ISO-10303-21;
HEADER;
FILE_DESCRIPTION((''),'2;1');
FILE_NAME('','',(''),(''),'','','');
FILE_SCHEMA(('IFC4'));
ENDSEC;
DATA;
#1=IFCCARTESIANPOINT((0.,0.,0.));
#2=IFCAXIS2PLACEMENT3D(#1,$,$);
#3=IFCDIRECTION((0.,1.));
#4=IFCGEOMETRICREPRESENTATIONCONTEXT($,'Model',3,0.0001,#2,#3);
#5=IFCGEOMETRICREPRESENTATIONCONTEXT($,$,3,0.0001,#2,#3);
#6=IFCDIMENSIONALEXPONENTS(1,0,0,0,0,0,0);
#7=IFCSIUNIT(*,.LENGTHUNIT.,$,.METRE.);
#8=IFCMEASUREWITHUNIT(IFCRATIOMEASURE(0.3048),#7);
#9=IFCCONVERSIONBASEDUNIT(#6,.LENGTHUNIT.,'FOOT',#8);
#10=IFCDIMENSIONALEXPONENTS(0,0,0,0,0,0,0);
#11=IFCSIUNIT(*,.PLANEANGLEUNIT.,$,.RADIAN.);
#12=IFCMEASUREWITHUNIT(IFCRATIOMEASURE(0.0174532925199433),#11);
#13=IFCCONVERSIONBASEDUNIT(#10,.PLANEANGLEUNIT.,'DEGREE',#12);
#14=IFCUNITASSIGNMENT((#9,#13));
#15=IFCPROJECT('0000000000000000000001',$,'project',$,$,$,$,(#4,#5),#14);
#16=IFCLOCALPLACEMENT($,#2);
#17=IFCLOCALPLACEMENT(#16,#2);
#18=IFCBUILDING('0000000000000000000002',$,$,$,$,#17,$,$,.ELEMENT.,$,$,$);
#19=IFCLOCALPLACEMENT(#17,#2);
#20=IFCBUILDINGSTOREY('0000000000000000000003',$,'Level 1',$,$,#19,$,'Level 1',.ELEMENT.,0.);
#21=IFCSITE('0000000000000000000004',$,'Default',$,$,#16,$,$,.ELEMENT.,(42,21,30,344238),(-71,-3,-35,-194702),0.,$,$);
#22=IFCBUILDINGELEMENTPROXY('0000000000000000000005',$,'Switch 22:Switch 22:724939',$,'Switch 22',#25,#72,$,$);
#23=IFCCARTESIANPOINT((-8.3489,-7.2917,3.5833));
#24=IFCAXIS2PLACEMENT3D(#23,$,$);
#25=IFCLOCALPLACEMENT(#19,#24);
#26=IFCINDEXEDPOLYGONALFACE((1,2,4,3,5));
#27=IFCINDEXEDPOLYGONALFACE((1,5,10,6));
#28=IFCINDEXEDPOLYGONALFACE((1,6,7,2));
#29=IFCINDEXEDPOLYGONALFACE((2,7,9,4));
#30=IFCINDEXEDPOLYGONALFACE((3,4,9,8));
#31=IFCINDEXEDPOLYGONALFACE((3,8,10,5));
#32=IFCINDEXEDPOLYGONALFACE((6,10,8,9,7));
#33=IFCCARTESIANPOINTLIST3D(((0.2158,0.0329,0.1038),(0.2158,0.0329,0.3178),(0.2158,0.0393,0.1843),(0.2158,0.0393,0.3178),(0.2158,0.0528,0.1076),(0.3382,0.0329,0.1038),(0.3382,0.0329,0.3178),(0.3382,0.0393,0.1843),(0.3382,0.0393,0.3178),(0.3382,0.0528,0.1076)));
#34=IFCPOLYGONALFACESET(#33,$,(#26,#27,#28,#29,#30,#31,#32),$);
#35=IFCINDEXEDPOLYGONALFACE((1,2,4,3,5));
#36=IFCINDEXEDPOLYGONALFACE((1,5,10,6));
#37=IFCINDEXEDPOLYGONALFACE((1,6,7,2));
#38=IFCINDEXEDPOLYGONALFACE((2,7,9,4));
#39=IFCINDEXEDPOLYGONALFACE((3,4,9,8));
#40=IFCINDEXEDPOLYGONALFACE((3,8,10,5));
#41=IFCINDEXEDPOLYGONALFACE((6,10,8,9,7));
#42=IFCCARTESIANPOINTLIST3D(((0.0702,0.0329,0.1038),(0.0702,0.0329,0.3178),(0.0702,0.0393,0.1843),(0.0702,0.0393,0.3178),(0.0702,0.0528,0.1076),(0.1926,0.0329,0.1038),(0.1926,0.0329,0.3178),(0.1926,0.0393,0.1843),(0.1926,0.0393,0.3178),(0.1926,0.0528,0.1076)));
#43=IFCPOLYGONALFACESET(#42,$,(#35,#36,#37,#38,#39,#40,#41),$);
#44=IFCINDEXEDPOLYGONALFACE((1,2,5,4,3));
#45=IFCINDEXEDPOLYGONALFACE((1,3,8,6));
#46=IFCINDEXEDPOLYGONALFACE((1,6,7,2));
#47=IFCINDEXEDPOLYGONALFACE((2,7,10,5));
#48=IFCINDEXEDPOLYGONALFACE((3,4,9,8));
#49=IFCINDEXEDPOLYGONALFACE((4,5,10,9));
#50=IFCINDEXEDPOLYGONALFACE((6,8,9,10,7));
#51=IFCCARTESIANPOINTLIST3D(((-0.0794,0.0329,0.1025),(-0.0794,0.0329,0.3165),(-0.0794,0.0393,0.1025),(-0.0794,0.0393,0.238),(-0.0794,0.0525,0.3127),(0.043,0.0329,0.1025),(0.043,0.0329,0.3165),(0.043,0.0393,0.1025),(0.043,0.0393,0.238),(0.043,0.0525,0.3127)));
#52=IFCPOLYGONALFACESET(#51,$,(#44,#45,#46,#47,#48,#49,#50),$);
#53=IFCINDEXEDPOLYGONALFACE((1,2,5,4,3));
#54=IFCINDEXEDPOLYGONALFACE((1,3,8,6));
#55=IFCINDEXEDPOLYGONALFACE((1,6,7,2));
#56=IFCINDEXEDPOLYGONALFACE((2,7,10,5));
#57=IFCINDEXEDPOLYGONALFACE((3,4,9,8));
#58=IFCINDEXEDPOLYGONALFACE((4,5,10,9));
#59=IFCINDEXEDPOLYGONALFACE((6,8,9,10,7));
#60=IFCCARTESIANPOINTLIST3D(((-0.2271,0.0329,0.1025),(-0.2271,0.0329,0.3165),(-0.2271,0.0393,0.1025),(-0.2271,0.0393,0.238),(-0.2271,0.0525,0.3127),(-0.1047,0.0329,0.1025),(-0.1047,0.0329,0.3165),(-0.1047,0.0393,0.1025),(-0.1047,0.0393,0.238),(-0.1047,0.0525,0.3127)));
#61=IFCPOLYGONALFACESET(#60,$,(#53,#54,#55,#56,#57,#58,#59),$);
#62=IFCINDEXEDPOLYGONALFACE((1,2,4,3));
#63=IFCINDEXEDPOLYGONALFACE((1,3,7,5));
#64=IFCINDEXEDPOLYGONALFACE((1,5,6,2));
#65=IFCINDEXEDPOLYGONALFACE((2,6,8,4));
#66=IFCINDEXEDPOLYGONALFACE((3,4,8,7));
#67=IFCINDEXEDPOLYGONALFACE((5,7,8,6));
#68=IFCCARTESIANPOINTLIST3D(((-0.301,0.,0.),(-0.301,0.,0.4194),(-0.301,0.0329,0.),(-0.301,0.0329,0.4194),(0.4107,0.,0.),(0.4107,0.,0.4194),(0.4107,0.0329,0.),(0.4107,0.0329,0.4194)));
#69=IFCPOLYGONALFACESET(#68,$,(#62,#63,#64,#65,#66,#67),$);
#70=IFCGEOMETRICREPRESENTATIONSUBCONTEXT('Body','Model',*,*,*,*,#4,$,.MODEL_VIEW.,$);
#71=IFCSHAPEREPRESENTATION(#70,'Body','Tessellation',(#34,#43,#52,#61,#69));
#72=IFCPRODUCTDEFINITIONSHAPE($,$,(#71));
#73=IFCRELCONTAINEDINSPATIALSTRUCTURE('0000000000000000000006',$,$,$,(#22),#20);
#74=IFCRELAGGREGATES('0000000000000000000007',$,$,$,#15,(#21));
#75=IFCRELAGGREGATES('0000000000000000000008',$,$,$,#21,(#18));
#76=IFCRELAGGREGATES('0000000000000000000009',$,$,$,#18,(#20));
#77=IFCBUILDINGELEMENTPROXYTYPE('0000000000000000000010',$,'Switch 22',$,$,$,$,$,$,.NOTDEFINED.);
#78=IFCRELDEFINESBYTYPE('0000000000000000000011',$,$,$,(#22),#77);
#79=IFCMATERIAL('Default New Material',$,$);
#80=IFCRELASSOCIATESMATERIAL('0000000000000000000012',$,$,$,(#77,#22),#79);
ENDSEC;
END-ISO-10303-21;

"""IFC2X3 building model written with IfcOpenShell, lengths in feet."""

from ifc_helpers import new_model, entity, si_unit, converted_unit, direction, frame, origin, origin_2d_with_axis, place, context, subcontext, project, spatial, polyline, rectangle, outline, extrude, source, transform, mapped, material, type_object, type_shapes, element, save


model = new_model("IFC2X3")

# Units and contexts
model_context = context("Model", 3, precision=0.0001, world=origin(), true_north=direction((0.0, 1.0)))
context_of_model = context(None, 3, precision=0.0001, world=origin(), true_north=direction((0.0, 1.0)))
body_context = subcontext(model_context, "Body", "Model", "MODEL_VIEW")
ifc_project = project(units=[converted_unit("LENGTHUNIT", "FOOT", entity("IfcRatioMeasure", 0.3048), si_unit("LENGTHUNIT", "METRE"), dimensions=[1, 0, 0, 0, 0, 0, 0]), converted_unit("PLANEANGLEUNIT", "DEGREE", entity("IfcRatioMeasure", 0.0174532925199433), si_unit("PLANEANGLEUNIT", "RADIAN"), dimensions=[0, 0, 0, 0, 0, 0, 0])], contexts=[model_context, context_of_model])

# Site, building, storey
site_placement = place(None, origin())
site = spatial("IfcSite", under=ifc_project, at=site_placement, Name="Default", CompositionType="ELEMENT", RefLatitude=(42, 21, 30, 344238), RefLongitude=(-71, -3, -35, -194702), RefElevation=0.0)
building_placement = place(site_placement, origin())
building = spatial("IfcBuilding", under=site, at=building_placement, CompositionType="ELEMENT")
storey_placement = place(building_placement, origin())
storey = spatial("IfcBuildingStorey", under=building, at=storey_placement, Name="Level 1", LongName="Level 1", CompositionType="ELEMENT", Elevation=0.0)

# Shared definitions
ifc_material = material(Name="Default New Material")

# Building element proxy
building_element_proxy_type_1 = type_object("IfcBuildingElementProxyType", Name="Switch 22", PredefinedType="NOTDEFINED", material=ifc_material)
shared_shape_1 = source(origin(), body_context, "Body", "SweptSolid", [
    extrude(outline(polyline([(-0.026, -0.0993), (-0.0057, -0.0993), (-0.0043, -0.0216), (0.0212, 0.1095), (0.0148, 0.1107), (-0.026, -0.0993)])), frame((0.2158, 0.0394, 0.2062), z_axis=(1.0, 0.0, 0.0), x_axis=(0.0, 0.981627, 0.190809)), (0.0, 0.0, 1.0), 0.1224),
    extrude(outline(polyline([(-0.026, -0.0993), (-0.0057, -0.0993), (-0.0043, -0.0216), (0.0212, 0.1095), (0.0148, 0.1107), (-0.026, -0.0993)])), frame((0.0702, 0.0394, 0.2062), z_axis=(1.0, 0.0, 0.0), x_axis=(0.0, 0.981627, 0.190809)), (0.0, 0.0, 1.0), 0.1224),
    extrude(outline(polyline([(-0.1021, -0.0065), (0.1119, -0.0065), (0.1119, -0.0001), (-0.0236, -0.0001), (-0.0983, 0.0131), (-0.1021, -0.0065)])), frame((-0.0794, 0.0394, 0.2145), z_axis=(1.0, 0.0, 0.0), x_axis=(0.0, 0.0, -1.0)), (0.0, 0.0, 1.0), 0.1224),
    extrude(outline(polyline([(-0.1021, -0.0065), (0.1119, -0.0065), (0.1119, -0.0001), (-0.0236, -0.0001), (-0.0983, 0.0131), (-0.1021, -0.0065)])), frame((-0.2271, 0.0394, 0.2145), z_axis=(1.0, 0.0, 0.0), x_axis=(0.0, 0.0, -1.0)), (0.0, 0.0, 1.0), 0.1224),
    extrude(rectangle(XDim=0.0329, YDim=0.7116, at=origin_2d_with_axis()), frame((0.0548, 0.0164, 0.0), z_axis=(0.0, 0.0, 1.0), x_axis=(0.0, -1.0, 0.0)), (0.0, 0.0, 1.0), 0.4194),
])
type_shapes(building_element_proxy_type_1, [shared_shape_1])
proxy_1_placement = place(storey_placement, frame((-8.3489, -7.2917, 3.5833)))
element("IfcBuildingElementProxy", 1, at=proxy_1_placement, inside=storey, type_object=building_element_proxy_type_1, material=ifc_material, Name="Switch 22:Switch 22:724939", ObjectType="Switch 22", context=body_context, shape_type="MappedRepresentation", body=[
    mapped(shared_shape_1, transform((0.0, 0.0, 0.0), scale=1.0)),
])

save(model, "model.ifc")
